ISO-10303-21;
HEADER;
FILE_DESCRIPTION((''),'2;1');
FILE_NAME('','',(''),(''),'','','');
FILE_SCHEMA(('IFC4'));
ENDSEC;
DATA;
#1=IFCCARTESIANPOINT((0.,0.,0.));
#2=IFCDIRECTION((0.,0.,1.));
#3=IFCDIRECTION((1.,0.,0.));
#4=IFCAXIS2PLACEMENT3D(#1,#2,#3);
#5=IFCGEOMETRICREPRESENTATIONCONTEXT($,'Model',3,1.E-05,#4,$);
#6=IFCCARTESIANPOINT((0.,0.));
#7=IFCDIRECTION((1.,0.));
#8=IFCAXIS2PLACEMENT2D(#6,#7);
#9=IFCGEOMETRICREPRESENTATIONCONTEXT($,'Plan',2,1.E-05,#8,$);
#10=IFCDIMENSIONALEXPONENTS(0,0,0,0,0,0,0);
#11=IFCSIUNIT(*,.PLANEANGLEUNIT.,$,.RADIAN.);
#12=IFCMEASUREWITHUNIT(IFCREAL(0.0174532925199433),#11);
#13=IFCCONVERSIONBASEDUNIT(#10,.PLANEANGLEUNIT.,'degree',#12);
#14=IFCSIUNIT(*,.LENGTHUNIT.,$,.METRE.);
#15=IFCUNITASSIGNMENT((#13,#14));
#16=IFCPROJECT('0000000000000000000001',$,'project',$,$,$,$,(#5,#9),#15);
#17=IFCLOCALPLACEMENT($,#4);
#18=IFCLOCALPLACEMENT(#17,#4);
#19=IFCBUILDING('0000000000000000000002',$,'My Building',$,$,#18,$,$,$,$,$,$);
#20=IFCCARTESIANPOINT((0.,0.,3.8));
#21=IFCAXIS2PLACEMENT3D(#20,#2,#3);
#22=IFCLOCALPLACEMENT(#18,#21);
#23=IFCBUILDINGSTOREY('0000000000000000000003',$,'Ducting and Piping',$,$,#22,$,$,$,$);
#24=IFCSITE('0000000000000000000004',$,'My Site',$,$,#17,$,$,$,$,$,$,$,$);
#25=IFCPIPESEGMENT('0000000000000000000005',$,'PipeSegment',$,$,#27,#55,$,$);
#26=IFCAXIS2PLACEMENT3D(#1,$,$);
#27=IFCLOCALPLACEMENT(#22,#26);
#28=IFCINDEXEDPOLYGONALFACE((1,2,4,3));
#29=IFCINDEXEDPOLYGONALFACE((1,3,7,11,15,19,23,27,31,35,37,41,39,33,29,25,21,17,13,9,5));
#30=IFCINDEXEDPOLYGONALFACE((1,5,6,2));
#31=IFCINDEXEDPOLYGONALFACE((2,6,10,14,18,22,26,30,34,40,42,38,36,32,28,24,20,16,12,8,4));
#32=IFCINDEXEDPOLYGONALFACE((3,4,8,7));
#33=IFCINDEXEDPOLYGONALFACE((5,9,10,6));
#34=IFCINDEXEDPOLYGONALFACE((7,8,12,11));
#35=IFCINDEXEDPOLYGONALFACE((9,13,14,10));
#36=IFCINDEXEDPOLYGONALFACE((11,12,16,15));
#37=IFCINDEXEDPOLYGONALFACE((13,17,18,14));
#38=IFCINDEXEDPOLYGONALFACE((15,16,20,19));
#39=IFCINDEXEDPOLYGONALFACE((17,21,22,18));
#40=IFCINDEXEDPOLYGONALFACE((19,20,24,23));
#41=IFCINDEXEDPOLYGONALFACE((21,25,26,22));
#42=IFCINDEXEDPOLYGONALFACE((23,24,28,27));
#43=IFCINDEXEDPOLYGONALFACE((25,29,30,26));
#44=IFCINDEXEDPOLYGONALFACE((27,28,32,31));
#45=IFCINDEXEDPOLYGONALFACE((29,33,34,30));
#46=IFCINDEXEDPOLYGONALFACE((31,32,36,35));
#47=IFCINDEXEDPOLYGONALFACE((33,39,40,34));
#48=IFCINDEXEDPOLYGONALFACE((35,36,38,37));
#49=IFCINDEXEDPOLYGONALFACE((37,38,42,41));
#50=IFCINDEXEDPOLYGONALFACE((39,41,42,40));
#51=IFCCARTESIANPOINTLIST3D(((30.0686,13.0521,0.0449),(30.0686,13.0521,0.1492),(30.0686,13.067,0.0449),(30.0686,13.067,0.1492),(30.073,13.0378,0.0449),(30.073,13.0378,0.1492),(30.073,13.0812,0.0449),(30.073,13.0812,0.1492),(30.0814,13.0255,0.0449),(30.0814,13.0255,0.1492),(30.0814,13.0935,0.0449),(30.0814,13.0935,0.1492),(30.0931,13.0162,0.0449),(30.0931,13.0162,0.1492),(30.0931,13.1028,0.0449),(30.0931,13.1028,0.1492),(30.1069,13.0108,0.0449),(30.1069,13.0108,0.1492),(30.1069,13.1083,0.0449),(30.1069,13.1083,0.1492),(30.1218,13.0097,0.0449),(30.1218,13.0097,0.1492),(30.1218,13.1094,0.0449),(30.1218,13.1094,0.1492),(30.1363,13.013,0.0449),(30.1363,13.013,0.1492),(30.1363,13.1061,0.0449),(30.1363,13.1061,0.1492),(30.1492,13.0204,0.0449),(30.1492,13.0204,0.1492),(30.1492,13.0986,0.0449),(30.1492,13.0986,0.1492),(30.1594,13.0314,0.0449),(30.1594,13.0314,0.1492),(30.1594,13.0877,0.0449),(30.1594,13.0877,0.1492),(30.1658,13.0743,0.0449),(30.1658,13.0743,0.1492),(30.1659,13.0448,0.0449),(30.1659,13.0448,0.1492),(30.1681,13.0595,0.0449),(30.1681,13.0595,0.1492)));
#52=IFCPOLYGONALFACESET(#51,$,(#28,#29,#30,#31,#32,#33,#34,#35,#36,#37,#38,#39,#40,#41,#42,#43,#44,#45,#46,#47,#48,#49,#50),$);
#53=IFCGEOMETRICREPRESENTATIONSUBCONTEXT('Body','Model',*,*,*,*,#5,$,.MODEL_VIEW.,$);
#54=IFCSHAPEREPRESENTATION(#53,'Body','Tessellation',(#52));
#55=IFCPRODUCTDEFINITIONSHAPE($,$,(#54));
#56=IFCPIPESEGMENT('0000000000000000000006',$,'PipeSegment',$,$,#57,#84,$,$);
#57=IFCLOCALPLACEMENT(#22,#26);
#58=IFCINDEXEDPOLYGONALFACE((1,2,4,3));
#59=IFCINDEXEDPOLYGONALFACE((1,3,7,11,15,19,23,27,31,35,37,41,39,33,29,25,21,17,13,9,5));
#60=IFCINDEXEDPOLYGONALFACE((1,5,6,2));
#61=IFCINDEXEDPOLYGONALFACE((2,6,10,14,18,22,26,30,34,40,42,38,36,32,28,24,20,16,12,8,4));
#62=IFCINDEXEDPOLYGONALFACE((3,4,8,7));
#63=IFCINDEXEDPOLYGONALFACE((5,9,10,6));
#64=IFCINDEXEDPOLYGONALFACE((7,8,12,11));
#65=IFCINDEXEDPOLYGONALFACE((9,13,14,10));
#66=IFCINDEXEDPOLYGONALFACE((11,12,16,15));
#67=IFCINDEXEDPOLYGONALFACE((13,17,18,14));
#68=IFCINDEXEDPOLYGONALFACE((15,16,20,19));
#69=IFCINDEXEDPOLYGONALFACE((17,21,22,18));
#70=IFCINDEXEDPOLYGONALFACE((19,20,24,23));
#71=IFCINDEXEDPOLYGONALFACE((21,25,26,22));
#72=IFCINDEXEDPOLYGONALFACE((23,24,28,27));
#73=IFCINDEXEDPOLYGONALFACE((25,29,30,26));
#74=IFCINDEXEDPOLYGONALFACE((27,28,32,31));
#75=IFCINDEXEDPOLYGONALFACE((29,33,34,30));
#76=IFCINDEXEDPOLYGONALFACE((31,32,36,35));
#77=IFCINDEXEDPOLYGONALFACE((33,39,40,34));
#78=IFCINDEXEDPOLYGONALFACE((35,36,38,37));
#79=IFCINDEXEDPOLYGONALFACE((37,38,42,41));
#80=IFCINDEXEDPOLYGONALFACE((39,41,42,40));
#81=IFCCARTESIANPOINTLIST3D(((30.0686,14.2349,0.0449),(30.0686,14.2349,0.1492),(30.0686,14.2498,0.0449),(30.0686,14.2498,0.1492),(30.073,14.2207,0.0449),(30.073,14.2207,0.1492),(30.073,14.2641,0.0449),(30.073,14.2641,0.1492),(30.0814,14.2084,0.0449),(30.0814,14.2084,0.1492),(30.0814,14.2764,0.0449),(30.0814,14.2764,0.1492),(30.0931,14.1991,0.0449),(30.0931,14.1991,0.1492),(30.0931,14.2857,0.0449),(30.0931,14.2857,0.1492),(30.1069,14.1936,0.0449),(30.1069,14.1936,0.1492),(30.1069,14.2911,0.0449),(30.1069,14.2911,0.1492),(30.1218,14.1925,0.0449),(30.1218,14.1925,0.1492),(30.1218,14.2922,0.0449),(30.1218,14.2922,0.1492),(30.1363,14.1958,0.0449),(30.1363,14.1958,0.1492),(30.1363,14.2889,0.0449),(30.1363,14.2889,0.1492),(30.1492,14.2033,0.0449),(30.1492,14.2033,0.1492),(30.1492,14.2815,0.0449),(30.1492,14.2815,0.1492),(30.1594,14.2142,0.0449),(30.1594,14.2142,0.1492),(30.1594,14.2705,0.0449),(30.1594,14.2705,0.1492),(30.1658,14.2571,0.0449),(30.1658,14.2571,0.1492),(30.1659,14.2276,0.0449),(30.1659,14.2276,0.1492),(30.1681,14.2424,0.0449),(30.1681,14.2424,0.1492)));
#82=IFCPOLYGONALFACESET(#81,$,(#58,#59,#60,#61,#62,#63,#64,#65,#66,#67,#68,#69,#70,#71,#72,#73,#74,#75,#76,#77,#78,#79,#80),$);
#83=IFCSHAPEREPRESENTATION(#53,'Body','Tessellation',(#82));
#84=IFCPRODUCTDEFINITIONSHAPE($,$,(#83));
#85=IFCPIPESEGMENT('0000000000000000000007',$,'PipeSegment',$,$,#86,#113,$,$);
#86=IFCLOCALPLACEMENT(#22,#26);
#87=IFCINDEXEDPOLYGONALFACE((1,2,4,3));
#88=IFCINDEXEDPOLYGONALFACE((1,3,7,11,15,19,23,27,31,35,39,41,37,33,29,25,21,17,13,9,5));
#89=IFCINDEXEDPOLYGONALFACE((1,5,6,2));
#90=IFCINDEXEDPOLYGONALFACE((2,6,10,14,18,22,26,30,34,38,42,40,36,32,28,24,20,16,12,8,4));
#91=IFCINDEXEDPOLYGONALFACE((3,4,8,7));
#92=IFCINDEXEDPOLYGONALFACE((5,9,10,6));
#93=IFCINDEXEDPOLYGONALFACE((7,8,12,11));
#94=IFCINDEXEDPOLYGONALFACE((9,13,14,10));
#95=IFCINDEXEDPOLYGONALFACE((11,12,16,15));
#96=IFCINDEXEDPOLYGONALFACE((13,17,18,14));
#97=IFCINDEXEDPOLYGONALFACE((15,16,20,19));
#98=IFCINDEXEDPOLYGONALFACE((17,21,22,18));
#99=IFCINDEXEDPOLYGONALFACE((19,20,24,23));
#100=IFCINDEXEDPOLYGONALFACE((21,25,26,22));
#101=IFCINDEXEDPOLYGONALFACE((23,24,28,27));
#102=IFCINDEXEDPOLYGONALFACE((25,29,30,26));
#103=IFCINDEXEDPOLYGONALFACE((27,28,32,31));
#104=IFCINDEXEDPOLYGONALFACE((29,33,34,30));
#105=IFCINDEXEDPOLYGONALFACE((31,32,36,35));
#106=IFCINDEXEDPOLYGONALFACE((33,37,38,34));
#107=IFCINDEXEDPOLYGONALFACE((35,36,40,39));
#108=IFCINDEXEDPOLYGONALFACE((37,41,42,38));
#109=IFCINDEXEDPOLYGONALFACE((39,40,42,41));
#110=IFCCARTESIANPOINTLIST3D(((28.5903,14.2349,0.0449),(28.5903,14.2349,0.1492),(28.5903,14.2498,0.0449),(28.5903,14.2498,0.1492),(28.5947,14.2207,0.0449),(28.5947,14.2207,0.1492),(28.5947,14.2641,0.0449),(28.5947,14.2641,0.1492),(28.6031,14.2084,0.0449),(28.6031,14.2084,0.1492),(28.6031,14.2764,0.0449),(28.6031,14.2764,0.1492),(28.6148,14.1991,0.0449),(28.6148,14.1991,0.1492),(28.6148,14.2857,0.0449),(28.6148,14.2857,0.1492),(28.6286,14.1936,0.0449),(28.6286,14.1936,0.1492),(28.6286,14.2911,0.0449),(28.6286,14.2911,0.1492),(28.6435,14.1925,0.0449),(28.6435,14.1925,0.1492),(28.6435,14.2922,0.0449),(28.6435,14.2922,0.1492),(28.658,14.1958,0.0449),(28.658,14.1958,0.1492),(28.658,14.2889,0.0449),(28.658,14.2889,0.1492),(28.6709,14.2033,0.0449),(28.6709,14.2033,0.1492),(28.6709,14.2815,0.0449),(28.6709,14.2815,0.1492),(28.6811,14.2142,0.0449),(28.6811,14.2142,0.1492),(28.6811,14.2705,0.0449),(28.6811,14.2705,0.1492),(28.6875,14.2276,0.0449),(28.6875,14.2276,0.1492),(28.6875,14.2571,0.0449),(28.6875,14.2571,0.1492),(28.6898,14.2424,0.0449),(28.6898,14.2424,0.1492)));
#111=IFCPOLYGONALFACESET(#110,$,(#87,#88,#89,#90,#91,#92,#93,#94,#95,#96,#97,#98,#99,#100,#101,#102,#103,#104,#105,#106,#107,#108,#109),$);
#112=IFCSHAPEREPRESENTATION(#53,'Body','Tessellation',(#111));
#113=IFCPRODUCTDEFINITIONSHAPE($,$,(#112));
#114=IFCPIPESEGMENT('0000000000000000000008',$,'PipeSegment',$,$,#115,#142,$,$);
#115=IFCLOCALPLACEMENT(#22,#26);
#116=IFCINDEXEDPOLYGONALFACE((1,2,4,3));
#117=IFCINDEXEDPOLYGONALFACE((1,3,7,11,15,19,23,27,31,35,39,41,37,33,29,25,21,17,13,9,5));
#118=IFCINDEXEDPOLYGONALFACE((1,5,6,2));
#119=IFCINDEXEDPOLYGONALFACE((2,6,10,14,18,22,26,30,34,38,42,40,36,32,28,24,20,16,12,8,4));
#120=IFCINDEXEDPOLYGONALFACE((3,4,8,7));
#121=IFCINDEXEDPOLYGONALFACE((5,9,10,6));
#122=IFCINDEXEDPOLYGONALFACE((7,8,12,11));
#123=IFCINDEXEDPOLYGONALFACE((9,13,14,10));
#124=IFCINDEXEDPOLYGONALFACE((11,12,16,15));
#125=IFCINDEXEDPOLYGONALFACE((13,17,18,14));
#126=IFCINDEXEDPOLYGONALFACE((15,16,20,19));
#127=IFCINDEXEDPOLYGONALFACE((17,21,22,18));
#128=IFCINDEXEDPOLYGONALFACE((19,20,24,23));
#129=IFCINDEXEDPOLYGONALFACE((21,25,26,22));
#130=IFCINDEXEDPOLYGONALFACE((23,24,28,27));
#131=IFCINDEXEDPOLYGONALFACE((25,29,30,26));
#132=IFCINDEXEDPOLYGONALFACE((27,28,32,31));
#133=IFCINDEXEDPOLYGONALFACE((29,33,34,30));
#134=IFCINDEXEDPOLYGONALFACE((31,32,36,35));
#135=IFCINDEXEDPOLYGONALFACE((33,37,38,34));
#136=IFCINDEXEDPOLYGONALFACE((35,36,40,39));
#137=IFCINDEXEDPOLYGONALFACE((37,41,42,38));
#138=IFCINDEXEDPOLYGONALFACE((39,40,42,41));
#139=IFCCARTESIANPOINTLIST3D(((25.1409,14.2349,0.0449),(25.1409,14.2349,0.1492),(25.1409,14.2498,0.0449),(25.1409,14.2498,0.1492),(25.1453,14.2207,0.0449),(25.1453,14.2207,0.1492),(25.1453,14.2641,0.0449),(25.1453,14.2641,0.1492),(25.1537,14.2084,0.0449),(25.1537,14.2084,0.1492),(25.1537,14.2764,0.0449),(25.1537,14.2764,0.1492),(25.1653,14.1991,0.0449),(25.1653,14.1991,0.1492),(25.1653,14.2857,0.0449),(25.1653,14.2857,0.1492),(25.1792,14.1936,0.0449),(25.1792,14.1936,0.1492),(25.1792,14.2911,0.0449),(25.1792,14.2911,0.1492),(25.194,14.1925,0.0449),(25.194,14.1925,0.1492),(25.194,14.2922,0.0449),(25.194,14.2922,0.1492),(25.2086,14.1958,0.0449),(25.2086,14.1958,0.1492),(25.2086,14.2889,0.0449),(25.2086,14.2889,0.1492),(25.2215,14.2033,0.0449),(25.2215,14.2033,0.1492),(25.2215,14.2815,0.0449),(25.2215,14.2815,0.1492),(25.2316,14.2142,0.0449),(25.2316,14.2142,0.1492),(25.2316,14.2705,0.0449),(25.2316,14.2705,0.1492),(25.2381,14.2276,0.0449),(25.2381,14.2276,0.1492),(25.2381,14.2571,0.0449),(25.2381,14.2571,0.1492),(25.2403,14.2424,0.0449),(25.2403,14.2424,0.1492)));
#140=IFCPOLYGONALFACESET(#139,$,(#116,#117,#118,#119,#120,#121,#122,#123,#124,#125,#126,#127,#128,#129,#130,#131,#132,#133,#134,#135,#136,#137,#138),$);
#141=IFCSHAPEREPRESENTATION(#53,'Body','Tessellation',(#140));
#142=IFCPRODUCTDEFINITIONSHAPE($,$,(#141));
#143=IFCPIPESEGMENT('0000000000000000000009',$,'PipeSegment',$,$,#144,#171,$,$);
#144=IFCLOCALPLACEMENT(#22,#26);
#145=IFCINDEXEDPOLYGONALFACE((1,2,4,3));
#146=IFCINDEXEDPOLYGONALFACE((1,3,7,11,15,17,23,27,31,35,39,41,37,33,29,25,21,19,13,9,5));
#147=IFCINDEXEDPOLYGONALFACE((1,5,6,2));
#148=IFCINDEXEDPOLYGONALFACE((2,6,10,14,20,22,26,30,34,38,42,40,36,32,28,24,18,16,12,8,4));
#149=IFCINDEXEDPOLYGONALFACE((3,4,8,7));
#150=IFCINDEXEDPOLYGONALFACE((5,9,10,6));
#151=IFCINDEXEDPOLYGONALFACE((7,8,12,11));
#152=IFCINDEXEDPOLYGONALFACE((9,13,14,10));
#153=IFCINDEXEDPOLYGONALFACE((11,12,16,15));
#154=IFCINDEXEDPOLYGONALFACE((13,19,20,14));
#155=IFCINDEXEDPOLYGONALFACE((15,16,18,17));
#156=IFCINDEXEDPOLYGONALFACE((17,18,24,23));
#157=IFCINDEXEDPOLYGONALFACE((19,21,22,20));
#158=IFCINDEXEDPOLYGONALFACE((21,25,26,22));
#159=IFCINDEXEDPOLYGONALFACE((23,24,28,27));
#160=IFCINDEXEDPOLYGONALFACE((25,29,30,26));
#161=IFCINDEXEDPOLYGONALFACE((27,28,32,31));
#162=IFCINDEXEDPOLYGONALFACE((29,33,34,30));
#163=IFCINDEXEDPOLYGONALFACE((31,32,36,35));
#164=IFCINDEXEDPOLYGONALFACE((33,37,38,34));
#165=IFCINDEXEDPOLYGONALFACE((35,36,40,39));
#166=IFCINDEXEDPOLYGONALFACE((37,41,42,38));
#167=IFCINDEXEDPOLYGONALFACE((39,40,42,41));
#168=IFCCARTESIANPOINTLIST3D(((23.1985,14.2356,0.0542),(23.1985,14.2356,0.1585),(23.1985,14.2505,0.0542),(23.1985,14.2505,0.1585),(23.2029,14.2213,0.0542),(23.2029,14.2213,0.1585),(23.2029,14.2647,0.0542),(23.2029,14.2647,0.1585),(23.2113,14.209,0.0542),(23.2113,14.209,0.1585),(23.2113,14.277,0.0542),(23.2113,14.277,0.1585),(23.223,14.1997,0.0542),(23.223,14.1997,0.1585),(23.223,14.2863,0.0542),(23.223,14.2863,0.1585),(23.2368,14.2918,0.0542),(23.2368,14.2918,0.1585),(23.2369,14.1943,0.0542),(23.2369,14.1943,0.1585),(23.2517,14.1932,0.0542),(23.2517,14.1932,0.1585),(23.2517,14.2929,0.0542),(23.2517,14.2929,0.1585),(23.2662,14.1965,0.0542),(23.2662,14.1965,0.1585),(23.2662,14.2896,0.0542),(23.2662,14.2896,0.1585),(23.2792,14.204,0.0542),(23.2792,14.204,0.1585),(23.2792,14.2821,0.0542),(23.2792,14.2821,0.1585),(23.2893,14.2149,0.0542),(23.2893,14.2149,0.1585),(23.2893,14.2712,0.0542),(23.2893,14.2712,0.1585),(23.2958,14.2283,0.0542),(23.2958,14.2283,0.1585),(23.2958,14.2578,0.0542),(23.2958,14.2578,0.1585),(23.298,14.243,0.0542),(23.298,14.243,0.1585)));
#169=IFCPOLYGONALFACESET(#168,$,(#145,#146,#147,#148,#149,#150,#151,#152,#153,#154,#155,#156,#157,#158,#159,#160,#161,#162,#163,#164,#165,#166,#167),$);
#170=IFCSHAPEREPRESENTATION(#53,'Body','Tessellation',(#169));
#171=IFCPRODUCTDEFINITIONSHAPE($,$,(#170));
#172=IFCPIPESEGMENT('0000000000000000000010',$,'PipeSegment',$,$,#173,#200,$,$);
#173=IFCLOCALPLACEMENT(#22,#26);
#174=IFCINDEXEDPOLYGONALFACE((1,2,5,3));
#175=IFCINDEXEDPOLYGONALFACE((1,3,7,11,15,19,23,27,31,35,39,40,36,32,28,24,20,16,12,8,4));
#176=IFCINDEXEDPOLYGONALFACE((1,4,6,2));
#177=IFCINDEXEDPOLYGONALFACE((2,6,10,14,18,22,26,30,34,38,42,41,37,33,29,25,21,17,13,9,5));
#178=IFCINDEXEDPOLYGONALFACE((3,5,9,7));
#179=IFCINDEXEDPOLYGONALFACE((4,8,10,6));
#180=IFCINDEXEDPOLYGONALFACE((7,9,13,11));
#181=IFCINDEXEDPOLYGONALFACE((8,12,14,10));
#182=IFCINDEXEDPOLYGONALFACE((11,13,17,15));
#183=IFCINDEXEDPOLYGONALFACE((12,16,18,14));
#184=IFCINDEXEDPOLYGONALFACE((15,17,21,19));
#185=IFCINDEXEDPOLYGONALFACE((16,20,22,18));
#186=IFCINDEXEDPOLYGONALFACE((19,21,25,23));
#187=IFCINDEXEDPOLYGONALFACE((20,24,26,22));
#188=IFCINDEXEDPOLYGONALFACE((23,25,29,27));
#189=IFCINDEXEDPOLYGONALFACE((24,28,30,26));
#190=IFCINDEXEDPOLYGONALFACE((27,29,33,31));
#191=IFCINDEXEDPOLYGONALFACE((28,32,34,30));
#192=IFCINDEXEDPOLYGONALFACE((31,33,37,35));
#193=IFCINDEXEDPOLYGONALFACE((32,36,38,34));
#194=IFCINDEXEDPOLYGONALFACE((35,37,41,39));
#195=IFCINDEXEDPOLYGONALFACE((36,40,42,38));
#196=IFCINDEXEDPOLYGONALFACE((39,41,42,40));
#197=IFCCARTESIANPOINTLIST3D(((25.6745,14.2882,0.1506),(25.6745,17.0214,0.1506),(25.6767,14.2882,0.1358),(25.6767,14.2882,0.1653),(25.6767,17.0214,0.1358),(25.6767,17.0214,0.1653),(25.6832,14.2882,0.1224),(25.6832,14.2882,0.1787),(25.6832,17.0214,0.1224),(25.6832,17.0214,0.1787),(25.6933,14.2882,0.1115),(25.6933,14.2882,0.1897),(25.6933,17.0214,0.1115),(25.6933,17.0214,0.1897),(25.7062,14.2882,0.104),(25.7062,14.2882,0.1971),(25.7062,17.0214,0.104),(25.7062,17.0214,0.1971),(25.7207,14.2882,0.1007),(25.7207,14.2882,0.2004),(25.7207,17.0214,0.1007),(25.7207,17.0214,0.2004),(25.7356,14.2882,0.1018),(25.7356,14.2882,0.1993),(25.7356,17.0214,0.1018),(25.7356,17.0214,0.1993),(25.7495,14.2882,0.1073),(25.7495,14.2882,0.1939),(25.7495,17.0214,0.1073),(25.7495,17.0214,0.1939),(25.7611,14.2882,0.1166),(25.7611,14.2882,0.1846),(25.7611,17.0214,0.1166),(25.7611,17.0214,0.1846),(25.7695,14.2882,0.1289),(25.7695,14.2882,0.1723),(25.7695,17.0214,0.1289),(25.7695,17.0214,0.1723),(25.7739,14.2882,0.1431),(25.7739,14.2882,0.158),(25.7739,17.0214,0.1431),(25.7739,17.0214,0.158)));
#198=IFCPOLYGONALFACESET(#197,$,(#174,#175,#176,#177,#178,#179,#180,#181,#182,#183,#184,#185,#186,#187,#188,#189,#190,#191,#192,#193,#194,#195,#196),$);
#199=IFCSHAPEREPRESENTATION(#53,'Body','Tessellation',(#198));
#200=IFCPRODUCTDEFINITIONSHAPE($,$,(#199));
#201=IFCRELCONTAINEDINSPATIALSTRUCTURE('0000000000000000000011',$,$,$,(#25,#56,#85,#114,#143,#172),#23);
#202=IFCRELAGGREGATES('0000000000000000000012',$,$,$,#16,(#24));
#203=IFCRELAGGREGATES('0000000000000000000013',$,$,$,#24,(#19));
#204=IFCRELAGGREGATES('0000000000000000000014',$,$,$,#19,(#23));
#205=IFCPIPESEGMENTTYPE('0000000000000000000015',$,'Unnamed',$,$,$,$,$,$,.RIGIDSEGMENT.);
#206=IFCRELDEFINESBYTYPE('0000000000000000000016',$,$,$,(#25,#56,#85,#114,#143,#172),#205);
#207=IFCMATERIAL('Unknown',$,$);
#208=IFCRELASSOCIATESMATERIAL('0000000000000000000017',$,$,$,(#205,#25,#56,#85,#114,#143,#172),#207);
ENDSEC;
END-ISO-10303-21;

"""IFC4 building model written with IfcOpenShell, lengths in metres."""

from ifc_helpers import new_model, entity, si_unit, converted_unit, frame, origin_with_axes, origin_2d_with_axis, place, context, subcontext, project, spatial, circle, extrude, material, material_profile, profile_set, profile_usage, type_object, element, save


model = new_model("IFC4")

# Units and contexts
model_context = context("Model", 3, precision=1e-05, world=origin_with_axes())
plan_context = context("Plan", 2, precision=1e-05, world=origin_2d_with_axis())
body_context = subcontext(model_context, "Body", "Model", "MODEL_VIEW")
ifc_project = project(units=[converted_unit("PLANEANGLEUNIT", "degree", entity("IfcReal", 0.0174532925199433), si_unit("PLANEANGLEUNIT", "RADIAN"), dimensions=[0, 0, 0, 0, 0, 0, 0]), si_unit("LENGTHUNIT", "METRE")], contexts=[model_context, plan_context])

# Site, building, storey
site_placement = place(None, origin_with_axes())
site = spatial("IfcSite", under=ifc_project, at=site_placement, Name="My Site")
building_placement = place(site_placement, origin_with_axes())
building = spatial("IfcBuilding", under=site, at=building_placement, Name="My Building")
storey_placement = place(building_placement, frame((0.0, 0.0, 3.8), z_axis=(0.0, 0.0, 1.0), x_axis=(1.0, 0.0, 0.0)))
storey = spatial("IfcBuildingStorey", under=building, at=storey_placement, Name="Ducting and Piping")

# Pipe segments
ifc_material = material(Name="Unknown")
ifc_material_profile_1 = material_profile(ifc_material, circle(Radius=0.05))
ifc_profile_set_1 = profile_set([ifc_material_profile_1])
pipe_segment_type = type_object("IfcPipeSegmentType", Name="Unnamed", PredefinedType="RIGIDSEGMENT", material=ifc_profile_set_1)
ifc_profile_usage_1 = profile_usage(ifc_profile_set_1, cardinal=5)
pipe_segment_1_placement = place(storey_placement, frame((30.1181, 13.0595, 0.0449), z_axis=(0.0, 0.0, 1.0), x_axis=(1.0, 0.00006, 0.0)))
element("IfcPipeSegment", 1, at=pipe_segment_1_placement, inside=storey, type_object=pipe_segment_type, material=ifc_profile_usage_1, Name="PipeSegment", context=body_context, shape_type="SweptSolid", body=[
    extrude(circle(Radius=0.05), origin_with_axes(), (0.0, 0.0, 1.0), 0.1043),
])
ifc_profile_usage_2 = profile_usage(ifc_profile_set_1, cardinal=5)
pipe_segment_2_placement = place(storey_placement, frame((30.1181, 14.2424, 0.0449), z_axis=(0.0, 0.0, 1.0), x_axis=(1.0, 0.00006, 0.0)))
element("IfcPipeSegment", 2, at=pipe_segment_2_placement, inside=storey, type_object=pipe_segment_type, material=ifc_profile_usage_2, Name="PipeSegment", context=body_context, shape_type="SweptSolid", body=[
    extrude(circle(Radius=0.05), origin_with_axes(), (0.0, 0.0, 1.0), 0.1043),
])
ifc_profile_usage_3 = profile_usage(ifc_profile_set_1, cardinal=5)
pipe_segment_3_placement = place(storey_placement, frame((28.6398, 14.2424, 0.0449), z_axis=(0.0, 0.0, 1.0), x_axis=(1.0, 0.00006, 0.0)))
element("IfcPipeSegment", 3, at=pipe_segment_3_placement, inside=storey, type_object=pipe_segment_type, material=ifc_profile_usage_3, Name="PipeSegment", context=body_context, shape_type="SweptSolid", body=[
    extrude(circle(Radius=0.05), origin_with_axes(), (0.0, 0.0, 1.0), 0.1043),
])
ifc_profile_usage_4 = profile_usage(ifc_profile_set_1, cardinal=5)
pipe_segment_4_placement = place(storey_placement, frame((25.1903, 14.2424, 0.0449), z_axis=(0.0, 0.0, 1.0), x_axis=(1.0, 0.00006, 0.0)))
element("IfcPipeSegment", 4, at=pipe_segment_4_placement, inside=storey, type_object=pipe_segment_type, material=ifc_profile_usage_4, Name="PipeSegment", context=body_context, shape_type="SweptSolid", body=[
    extrude(circle(Radius=0.05), origin_with_axes(), (0.0, 0.0, 1.0), 0.1043),
])
ifc_profile_usage_5 = profile_usage(ifc_profile_set_1, cardinal=5)
pipe_segment_5_placement = place(storey_placement, frame((23.248, 14.243, 0.0542), z_axis=(0.0, 0.0, 1.0), x_axis=(1.0, 0.00006, 0.0)))
element("IfcPipeSegment", 5, at=pipe_segment_5_placement, inside=storey, type_object=pipe_segment_type, material=ifc_profile_usage_5, Name="PipeSegment", context=body_context, shape_type="SweptSolid", body=[
    extrude(circle(Radius=0.05), origin_with_axes(), (0.0, 0.0, 1.0), 0.1043),
])
ifc_profile_usage_6 = profile_usage(ifc_profile_set_1, cardinal=5)
pipe_segment_6_placement = place(storey_placement, frame((25.7245, 14.2882, 0.1506), z_axis=(0.0, 1.0, 0.0), x_axis=(-1.0, 0.0, 0.0)))
element("IfcPipeSegment", 6, at=pipe_segment_6_placement, inside=storey, type_object=pipe_segment_type, material=ifc_profile_usage_6, Name="PipeSegment", context=body_context, shape_type="SweptSolid", body=[
    extrude(circle(Radius=0.05), origin_with_axes(), (0.0, 0.0, 1.0), 2.7332),
])

save(model, "model.ifc")
